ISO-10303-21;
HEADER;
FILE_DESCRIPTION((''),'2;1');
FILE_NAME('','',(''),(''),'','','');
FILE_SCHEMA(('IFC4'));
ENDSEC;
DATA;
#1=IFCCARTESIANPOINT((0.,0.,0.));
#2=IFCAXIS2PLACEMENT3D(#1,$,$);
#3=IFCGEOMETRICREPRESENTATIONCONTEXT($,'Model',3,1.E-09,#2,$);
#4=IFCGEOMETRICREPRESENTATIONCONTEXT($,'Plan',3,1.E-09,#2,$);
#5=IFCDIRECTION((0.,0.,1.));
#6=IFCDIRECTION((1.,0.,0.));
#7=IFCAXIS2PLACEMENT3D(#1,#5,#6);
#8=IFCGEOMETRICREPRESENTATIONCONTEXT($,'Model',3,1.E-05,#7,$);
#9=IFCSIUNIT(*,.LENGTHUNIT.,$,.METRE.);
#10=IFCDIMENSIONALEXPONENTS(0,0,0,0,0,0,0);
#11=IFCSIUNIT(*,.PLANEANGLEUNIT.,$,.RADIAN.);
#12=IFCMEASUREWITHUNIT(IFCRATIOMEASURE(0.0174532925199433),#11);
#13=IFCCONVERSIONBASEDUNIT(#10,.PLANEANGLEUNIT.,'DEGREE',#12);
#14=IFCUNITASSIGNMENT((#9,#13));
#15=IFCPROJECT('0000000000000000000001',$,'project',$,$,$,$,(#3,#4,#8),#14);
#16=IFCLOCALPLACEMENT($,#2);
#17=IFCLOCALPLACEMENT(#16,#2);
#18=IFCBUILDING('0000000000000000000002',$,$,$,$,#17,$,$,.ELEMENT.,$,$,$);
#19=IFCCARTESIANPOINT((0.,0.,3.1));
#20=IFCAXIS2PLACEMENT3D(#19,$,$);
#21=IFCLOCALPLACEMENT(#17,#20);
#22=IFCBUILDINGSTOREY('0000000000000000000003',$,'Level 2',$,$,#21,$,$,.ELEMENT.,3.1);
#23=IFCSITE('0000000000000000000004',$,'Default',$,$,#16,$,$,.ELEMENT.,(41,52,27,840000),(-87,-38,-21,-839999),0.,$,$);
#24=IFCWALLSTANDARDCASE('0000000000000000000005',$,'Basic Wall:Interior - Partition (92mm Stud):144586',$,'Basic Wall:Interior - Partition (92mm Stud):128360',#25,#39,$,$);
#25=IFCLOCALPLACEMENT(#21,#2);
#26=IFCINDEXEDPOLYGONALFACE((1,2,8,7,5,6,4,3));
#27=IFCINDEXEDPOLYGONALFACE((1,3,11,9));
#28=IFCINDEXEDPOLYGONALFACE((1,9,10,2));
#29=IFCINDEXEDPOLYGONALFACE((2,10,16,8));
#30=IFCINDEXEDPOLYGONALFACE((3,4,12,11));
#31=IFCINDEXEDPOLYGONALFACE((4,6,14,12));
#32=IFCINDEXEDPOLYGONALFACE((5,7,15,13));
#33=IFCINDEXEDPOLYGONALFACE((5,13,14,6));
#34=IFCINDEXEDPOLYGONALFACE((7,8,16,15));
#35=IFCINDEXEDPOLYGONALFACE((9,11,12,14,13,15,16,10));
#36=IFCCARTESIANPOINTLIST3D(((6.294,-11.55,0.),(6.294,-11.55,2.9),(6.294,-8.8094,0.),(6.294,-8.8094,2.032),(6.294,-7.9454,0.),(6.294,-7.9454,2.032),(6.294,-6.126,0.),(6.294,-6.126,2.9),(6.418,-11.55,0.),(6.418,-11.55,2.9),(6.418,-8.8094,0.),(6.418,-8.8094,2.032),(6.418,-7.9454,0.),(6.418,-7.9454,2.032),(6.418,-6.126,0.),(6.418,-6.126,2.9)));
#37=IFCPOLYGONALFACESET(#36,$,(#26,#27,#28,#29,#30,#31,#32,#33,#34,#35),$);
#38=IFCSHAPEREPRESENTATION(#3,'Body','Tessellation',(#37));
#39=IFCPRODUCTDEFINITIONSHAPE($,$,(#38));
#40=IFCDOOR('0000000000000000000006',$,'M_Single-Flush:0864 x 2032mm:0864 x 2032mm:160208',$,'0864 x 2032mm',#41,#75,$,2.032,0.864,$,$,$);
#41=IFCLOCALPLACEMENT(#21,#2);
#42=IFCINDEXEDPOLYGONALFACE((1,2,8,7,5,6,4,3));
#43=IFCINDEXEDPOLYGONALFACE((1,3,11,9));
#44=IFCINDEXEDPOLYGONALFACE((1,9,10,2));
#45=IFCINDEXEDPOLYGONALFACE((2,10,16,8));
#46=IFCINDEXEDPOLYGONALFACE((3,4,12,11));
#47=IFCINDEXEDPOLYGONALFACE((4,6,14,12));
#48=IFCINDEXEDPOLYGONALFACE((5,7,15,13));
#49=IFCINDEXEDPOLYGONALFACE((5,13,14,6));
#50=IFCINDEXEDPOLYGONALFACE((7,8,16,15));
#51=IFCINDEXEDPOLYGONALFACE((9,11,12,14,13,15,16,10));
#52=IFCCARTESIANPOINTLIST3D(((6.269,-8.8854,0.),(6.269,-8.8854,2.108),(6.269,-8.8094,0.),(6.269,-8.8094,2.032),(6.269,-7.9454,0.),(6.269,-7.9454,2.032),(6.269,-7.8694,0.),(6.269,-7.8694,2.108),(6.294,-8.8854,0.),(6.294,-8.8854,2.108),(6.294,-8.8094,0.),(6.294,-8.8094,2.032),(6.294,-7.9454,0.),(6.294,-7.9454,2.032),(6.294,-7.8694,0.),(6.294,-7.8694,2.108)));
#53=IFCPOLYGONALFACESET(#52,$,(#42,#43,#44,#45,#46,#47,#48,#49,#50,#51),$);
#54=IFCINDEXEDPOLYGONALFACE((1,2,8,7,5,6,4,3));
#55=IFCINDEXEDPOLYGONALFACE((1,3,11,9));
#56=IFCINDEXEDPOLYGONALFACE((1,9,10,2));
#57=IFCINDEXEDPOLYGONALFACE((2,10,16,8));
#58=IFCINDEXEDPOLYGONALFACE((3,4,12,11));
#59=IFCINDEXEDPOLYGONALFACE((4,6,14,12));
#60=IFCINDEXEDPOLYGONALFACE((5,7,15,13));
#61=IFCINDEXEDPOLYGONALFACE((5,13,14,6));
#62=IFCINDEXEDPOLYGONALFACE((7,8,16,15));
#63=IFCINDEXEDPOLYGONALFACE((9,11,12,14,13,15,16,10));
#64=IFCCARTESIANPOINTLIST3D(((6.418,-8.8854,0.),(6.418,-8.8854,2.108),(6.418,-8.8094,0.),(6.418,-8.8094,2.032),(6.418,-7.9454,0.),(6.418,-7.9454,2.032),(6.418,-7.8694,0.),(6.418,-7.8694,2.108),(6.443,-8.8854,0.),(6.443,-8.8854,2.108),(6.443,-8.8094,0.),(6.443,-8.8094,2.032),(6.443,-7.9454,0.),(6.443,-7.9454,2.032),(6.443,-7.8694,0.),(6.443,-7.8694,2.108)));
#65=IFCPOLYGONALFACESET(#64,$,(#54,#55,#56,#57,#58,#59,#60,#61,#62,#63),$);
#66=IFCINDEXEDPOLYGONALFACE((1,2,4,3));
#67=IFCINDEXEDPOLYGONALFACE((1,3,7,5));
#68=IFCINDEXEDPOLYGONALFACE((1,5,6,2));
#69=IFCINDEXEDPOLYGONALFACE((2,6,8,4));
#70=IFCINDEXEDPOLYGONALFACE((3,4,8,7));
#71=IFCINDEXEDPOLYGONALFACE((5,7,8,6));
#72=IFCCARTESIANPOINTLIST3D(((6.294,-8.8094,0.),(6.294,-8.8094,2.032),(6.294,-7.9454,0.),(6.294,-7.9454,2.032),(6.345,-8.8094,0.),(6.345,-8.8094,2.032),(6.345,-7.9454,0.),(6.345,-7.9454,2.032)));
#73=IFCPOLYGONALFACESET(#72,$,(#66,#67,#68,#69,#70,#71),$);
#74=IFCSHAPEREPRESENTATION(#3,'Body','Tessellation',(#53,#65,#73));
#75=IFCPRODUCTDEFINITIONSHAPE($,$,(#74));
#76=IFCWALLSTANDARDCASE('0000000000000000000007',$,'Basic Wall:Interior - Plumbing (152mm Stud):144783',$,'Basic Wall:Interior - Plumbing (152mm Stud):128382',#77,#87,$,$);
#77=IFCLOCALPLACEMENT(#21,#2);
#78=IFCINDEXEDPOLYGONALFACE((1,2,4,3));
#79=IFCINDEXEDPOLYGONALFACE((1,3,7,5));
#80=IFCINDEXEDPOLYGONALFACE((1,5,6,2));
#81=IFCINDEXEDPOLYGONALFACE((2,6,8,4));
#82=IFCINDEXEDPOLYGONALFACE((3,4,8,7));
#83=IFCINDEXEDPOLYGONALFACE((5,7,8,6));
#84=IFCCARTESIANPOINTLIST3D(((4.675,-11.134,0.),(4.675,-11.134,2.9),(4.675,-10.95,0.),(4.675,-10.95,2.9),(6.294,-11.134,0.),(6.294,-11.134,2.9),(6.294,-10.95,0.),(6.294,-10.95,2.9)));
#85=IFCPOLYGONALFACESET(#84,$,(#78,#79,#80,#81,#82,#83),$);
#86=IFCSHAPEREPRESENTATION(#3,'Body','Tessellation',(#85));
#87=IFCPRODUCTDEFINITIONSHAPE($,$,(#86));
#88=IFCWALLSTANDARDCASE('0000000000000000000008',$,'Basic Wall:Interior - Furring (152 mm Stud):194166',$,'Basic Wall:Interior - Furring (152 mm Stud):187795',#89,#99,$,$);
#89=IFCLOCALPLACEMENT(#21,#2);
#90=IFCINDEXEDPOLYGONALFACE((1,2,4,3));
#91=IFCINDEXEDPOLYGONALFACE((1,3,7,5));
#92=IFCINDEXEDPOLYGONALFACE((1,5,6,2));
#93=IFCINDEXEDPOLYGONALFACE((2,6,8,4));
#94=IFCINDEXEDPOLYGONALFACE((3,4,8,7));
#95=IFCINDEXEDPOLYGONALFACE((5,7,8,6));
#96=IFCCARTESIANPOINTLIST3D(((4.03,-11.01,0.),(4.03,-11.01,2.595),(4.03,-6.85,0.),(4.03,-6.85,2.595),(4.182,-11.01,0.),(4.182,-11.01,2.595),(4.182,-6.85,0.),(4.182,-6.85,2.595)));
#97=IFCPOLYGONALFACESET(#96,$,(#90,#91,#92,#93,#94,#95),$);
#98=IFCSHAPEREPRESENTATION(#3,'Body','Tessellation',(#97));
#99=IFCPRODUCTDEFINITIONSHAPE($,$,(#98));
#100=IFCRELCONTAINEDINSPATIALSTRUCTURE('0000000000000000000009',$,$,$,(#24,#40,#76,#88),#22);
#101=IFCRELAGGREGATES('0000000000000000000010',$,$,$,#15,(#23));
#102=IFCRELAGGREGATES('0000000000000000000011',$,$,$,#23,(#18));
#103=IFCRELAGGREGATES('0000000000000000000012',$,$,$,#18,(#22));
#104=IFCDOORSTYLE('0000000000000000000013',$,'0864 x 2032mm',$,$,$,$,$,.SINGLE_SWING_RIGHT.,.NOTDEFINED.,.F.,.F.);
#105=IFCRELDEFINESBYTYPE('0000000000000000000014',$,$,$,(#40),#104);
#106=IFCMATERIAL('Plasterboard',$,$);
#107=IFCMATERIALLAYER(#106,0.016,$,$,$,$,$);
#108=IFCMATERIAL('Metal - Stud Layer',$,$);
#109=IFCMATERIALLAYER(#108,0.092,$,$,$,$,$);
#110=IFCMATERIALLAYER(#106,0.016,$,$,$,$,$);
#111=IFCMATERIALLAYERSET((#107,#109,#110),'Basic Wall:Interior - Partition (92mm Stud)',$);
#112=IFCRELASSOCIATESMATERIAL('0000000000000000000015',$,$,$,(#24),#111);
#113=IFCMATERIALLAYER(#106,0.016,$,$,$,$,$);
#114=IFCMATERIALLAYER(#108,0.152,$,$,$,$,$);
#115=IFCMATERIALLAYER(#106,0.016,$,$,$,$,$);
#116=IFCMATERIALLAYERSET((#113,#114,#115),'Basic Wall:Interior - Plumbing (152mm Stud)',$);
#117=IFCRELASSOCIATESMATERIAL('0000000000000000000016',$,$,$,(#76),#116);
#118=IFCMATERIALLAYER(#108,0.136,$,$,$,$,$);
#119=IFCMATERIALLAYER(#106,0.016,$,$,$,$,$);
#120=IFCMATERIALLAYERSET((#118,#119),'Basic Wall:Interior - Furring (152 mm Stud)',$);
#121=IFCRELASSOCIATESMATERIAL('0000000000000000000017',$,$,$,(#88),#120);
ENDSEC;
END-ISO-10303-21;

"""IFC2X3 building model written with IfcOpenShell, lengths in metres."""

from ifc_helpers import new_model, entity, si_unit, converted_unit, frame, frame_2d, origin, origin_with_axes, origin_2d_with_axis, place, context, project, spatial, polyline, rectangle, outline, extrude, source, transform, mapped, material, layer, layer_set, layer_usage, type_object, type_shapes, element, fill, save


model = new_model("IFC2X3")

# Units and contexts
model_context_1 = context("Model", 3, precision=1e-09, world=origin())
plan_context = context("Plan", 3, precision=1e-09, world=origin())
model_context_2 = context("Model", 3, precision=1e-05, world=origin_with_axes())
ifc_project = project(units=[si_unit("LENGTHUNIT", "METRE"), converted_unit("PLANEANGLEUNIT", "DEGREE", entity("IfcRatioMeasure", 0.0174532925199433), si_unit("PLANEANGLEUNIT", "RADIAN"), dimensions=[0, 0, 0, 0, 0, 0, 0])], contexts=[model_context_1, plan_context, model_context_2])

# Site, building, storey
site_placement = place(None, origin())
site = spatial("IfcSite", under=ifc_project, at=site_placement, Name="Default", CompositionType="ELEMENT", RefLatitude=(41, 52, 27, 840000), RefLongitude=(-87, -38, -21, -839999), RefElevation=0.0)
building_placement = place(site_placement, origin())
building = spatial("IfcBuilding", under=site, at=building_placement, CompositionType="ELEMENT")
storey_placement = place(building_placement, frame((0.0, 0.0, 3.1)))
storey = spatial("IfcBuildingStorey", under=building, at=storey_placement, Name="Level 2", CompositionType="ELEMENT", Elevation=3.1)

# Shared definitions
ifc_material_1 = material(Name="Metal - Stud Layer")
ifc_material_2 = material(Name="Plasterboard")

# Shared definitions
ifc_layer_1 = layer(ifc_material_2, 0.016)
ifc_layer_2 = layer(ifc_material_1, 0.092)
ifc_layer_3 = layer(ifc_material_2, 0.016)
ifc_layer_set_1 = layer_set([ifc_layer_1, ifc_layer_2, ifc_layer_3], Name="Basic Wall:Interior - Partition (92mm Stud)")

# Wall, opening, door
ifc_layer_usage_1 = layer_usage(ifc_layer_set_1, "AXIS2", "NEGATIVE", 0.062)
wall_1_placement = place(storey_placement, frame((6.356, -11.55, 0.0), z_axis=(0.0, 0.0, 1.0), x_axis=(0.0, 1.0, 0.0)))
wall_1 = element("IfcWallStandardCase", 1, at=wall_1_placement, inside=storey, material=ifc_layer_usage_1, Name="Basic Wall:Interior - Partition (92mm Stud):144586", ObjectType="Basic Wall:Interior - Partition (92mm Stud):128360", context=model_context_1, shape_type="SweptSolid", body=[
    extrude(rectangle(XDim=5.424, YDim=0.124, at=frame_2d((2.712, 0.0), x_axis=(-1.0, 0.0))), origin(), (0.0, 0.0, 1.0), 2.9),
])
opening_1_placement = place(wall_1_placement, frame((2.7406, -0.062, 0.0)))
opening_1 = element("IfcOpeningElement", 2, at=opening_1_placement, cuts=wall_1, ObjectType="Opening", context=model_context_1, shape_type="SweptSolid", body=[
    extrude(rectangle(XDim=0.864, YDim=2.032, at=frame_2d((1.016, 0.432), x_axis=(0.0, 1.0))), frame((0.0, 0.0, 0.0), z_axis=(0.0, 1.0, 0.0), x_axis=(0.0, 0.0, 1.0)), (0.0, 0.0, 1.0), 0.124),
])
door_style = type_object("IfcDoorStyle", Name="0864 x 2032mm", ConstructionType="NOTDEFINED", OperationType="SINGLE_SWING_RIGHT", ParameterTakesPrecedence=False, Sizeable=False)
shared_shape_1 = source(origin(), model_context_1, "Body", "SweptSolid", [
    extrude(outline(polyline([(-0.508, -1.073), (0.508, -1.073), (0.508, 1.035), (0.432, 1.035), (0.432, -0.997), (-0.432, -0.997), (-0.432, 1.035), (-0.508, 1.035), (-0.508, -1.073)])), frame((0.432, 0.124, 1.035), z_axis=(0.0, 1.0, 0.0), x_axis=(1.0, 0.0, 0.0)), (0.0, 0.0, 1.0), 0.025),
    extrude(outline(polyline([(-1.073, -0.508), (1.035, -0.508), (1.035, -0.432), (-0.997, -0.432), (-0.997, 0.432), (1.035, 0.432), (1.035, 0.508), (-1.073, 0.508), (-1.073, -0.508)])), frame((0.432, -0.025, 1.035), z_axis=(0.0, 1.0, 0.0), x_axis=(0.0, 0.0, -1.0)), (0.0, 0.0, 1.0), 0.025),
    extrude(rectangle(XDim=0.051, YDim=0.864, at=origin_2d_with_axis()), frame((0.432, 0.0985, 0.0), z_axis=(0.0, 0.0, 1.0), x_axis=(0.0, 1.0, 0.0)), (0.0, 0.0, 1.0), 2.032),
])
type_shapes(door_style, [shared_shape_1])
door_placement = place(opening_1_placement, origin())
door = element("IfcDoor", 3, at=door_placement, inside=storey, type_object=door_style, Name="M_Single-Flush:0864 x 2032mm:0864 x 2032mm:160208", ObjectType="0864 x 2032mm", OverallHeight=2.032, OverallWidth=0.864, context=model_context_1, shape_type="MappedRepresentation", body=[
    mapped(shared_shape_1, transform((0.0, 0.0, 0.0), scale=1.0)),
])
fill(opening_1, door)

# Walls
ifc_layer_4 = layer(ifc_material_2, 0.016)
ifc_layer_5 = layer(ifc_material_1, 0.152)
ifc_layer_6 = layer(ifc_material_2, 0.016)
ifc_layer_set_2 = layer_set([ifc_layer_4, ifc_layer_5, ifc_layer_6], Name="Basic Wall:Interior - Plumbing (152mm Stud)")
ifc_layer_usage_2 = layer_usage(ifc_layer_set_2, "AXIS2", "NEGATIVE", 0.092)
wall_2_placement = place(storey_placement, frame((6.294, -11.042, 0.0), z_axis=(0.0, 0.0, 1.0), x_axis=(-1.0, 0.0, 0.0)))
element("IfcWallStandardCase", 4, at=wall_2_placement, inside=storey, material=ifc_layer_usage_2, Name="Basic Wall:Interior - Plumbing (152mm Stud):144783", ObjectType="Basic Wall:Interior - Plumbing (152mm Stud):128382", context=model_context_1, shape_type="SweptSolid", body=[
    extrude(rectangle(XDim=1.619, YDim=0.184, at=frame_2d((0.8095, 0.0), x_axis=(-1.0, 0.0))), origin(), (0.0, 0.0, 1.0), 2.9),
])
ifc_layer_7 = layer(ifc_material_1, 0.136)
ifc_layer_8 = layer(ifc_material_2, 0.016)
ifc_layer_set_3 = layer_set([ifc_layer_7, ifc_layer_8], Name="Basic Wall:Interior - Furring (152 mm Stud)")
ifc_layer_usage_3 = layer_usage(ifc_layer_set_3, "AXIS2", "POSITIVE", -0.076)
wall_3_placement = place(storey_placement, frame((4.106, -11.01, 0.0), z_axis=(0.0, 0.0, 1.0), x_axis=(0.0, 1.0, 0.0)))
element("IfcWallStandardCase", 5, at=wall_3_placement, inside=storey, material=ifc_layer_usage_3, Name="Basic Wall:Interior - Furring (152 mm Stud):194166", ObjectType="Basic Wall:Interior - Furring (152 mm Stud):187795", context=model_context_1, shape_type="SweptSolid", body=[
    extrude(rectangle(XDim=4.16, YDim=0.152, at=frame_2d((2.08, 0.0), x_axis=(-1.0, 0.0))), origin(), (0.0, 0.0, 1.0), 2.595),
])

save(model, "model.ifc")
